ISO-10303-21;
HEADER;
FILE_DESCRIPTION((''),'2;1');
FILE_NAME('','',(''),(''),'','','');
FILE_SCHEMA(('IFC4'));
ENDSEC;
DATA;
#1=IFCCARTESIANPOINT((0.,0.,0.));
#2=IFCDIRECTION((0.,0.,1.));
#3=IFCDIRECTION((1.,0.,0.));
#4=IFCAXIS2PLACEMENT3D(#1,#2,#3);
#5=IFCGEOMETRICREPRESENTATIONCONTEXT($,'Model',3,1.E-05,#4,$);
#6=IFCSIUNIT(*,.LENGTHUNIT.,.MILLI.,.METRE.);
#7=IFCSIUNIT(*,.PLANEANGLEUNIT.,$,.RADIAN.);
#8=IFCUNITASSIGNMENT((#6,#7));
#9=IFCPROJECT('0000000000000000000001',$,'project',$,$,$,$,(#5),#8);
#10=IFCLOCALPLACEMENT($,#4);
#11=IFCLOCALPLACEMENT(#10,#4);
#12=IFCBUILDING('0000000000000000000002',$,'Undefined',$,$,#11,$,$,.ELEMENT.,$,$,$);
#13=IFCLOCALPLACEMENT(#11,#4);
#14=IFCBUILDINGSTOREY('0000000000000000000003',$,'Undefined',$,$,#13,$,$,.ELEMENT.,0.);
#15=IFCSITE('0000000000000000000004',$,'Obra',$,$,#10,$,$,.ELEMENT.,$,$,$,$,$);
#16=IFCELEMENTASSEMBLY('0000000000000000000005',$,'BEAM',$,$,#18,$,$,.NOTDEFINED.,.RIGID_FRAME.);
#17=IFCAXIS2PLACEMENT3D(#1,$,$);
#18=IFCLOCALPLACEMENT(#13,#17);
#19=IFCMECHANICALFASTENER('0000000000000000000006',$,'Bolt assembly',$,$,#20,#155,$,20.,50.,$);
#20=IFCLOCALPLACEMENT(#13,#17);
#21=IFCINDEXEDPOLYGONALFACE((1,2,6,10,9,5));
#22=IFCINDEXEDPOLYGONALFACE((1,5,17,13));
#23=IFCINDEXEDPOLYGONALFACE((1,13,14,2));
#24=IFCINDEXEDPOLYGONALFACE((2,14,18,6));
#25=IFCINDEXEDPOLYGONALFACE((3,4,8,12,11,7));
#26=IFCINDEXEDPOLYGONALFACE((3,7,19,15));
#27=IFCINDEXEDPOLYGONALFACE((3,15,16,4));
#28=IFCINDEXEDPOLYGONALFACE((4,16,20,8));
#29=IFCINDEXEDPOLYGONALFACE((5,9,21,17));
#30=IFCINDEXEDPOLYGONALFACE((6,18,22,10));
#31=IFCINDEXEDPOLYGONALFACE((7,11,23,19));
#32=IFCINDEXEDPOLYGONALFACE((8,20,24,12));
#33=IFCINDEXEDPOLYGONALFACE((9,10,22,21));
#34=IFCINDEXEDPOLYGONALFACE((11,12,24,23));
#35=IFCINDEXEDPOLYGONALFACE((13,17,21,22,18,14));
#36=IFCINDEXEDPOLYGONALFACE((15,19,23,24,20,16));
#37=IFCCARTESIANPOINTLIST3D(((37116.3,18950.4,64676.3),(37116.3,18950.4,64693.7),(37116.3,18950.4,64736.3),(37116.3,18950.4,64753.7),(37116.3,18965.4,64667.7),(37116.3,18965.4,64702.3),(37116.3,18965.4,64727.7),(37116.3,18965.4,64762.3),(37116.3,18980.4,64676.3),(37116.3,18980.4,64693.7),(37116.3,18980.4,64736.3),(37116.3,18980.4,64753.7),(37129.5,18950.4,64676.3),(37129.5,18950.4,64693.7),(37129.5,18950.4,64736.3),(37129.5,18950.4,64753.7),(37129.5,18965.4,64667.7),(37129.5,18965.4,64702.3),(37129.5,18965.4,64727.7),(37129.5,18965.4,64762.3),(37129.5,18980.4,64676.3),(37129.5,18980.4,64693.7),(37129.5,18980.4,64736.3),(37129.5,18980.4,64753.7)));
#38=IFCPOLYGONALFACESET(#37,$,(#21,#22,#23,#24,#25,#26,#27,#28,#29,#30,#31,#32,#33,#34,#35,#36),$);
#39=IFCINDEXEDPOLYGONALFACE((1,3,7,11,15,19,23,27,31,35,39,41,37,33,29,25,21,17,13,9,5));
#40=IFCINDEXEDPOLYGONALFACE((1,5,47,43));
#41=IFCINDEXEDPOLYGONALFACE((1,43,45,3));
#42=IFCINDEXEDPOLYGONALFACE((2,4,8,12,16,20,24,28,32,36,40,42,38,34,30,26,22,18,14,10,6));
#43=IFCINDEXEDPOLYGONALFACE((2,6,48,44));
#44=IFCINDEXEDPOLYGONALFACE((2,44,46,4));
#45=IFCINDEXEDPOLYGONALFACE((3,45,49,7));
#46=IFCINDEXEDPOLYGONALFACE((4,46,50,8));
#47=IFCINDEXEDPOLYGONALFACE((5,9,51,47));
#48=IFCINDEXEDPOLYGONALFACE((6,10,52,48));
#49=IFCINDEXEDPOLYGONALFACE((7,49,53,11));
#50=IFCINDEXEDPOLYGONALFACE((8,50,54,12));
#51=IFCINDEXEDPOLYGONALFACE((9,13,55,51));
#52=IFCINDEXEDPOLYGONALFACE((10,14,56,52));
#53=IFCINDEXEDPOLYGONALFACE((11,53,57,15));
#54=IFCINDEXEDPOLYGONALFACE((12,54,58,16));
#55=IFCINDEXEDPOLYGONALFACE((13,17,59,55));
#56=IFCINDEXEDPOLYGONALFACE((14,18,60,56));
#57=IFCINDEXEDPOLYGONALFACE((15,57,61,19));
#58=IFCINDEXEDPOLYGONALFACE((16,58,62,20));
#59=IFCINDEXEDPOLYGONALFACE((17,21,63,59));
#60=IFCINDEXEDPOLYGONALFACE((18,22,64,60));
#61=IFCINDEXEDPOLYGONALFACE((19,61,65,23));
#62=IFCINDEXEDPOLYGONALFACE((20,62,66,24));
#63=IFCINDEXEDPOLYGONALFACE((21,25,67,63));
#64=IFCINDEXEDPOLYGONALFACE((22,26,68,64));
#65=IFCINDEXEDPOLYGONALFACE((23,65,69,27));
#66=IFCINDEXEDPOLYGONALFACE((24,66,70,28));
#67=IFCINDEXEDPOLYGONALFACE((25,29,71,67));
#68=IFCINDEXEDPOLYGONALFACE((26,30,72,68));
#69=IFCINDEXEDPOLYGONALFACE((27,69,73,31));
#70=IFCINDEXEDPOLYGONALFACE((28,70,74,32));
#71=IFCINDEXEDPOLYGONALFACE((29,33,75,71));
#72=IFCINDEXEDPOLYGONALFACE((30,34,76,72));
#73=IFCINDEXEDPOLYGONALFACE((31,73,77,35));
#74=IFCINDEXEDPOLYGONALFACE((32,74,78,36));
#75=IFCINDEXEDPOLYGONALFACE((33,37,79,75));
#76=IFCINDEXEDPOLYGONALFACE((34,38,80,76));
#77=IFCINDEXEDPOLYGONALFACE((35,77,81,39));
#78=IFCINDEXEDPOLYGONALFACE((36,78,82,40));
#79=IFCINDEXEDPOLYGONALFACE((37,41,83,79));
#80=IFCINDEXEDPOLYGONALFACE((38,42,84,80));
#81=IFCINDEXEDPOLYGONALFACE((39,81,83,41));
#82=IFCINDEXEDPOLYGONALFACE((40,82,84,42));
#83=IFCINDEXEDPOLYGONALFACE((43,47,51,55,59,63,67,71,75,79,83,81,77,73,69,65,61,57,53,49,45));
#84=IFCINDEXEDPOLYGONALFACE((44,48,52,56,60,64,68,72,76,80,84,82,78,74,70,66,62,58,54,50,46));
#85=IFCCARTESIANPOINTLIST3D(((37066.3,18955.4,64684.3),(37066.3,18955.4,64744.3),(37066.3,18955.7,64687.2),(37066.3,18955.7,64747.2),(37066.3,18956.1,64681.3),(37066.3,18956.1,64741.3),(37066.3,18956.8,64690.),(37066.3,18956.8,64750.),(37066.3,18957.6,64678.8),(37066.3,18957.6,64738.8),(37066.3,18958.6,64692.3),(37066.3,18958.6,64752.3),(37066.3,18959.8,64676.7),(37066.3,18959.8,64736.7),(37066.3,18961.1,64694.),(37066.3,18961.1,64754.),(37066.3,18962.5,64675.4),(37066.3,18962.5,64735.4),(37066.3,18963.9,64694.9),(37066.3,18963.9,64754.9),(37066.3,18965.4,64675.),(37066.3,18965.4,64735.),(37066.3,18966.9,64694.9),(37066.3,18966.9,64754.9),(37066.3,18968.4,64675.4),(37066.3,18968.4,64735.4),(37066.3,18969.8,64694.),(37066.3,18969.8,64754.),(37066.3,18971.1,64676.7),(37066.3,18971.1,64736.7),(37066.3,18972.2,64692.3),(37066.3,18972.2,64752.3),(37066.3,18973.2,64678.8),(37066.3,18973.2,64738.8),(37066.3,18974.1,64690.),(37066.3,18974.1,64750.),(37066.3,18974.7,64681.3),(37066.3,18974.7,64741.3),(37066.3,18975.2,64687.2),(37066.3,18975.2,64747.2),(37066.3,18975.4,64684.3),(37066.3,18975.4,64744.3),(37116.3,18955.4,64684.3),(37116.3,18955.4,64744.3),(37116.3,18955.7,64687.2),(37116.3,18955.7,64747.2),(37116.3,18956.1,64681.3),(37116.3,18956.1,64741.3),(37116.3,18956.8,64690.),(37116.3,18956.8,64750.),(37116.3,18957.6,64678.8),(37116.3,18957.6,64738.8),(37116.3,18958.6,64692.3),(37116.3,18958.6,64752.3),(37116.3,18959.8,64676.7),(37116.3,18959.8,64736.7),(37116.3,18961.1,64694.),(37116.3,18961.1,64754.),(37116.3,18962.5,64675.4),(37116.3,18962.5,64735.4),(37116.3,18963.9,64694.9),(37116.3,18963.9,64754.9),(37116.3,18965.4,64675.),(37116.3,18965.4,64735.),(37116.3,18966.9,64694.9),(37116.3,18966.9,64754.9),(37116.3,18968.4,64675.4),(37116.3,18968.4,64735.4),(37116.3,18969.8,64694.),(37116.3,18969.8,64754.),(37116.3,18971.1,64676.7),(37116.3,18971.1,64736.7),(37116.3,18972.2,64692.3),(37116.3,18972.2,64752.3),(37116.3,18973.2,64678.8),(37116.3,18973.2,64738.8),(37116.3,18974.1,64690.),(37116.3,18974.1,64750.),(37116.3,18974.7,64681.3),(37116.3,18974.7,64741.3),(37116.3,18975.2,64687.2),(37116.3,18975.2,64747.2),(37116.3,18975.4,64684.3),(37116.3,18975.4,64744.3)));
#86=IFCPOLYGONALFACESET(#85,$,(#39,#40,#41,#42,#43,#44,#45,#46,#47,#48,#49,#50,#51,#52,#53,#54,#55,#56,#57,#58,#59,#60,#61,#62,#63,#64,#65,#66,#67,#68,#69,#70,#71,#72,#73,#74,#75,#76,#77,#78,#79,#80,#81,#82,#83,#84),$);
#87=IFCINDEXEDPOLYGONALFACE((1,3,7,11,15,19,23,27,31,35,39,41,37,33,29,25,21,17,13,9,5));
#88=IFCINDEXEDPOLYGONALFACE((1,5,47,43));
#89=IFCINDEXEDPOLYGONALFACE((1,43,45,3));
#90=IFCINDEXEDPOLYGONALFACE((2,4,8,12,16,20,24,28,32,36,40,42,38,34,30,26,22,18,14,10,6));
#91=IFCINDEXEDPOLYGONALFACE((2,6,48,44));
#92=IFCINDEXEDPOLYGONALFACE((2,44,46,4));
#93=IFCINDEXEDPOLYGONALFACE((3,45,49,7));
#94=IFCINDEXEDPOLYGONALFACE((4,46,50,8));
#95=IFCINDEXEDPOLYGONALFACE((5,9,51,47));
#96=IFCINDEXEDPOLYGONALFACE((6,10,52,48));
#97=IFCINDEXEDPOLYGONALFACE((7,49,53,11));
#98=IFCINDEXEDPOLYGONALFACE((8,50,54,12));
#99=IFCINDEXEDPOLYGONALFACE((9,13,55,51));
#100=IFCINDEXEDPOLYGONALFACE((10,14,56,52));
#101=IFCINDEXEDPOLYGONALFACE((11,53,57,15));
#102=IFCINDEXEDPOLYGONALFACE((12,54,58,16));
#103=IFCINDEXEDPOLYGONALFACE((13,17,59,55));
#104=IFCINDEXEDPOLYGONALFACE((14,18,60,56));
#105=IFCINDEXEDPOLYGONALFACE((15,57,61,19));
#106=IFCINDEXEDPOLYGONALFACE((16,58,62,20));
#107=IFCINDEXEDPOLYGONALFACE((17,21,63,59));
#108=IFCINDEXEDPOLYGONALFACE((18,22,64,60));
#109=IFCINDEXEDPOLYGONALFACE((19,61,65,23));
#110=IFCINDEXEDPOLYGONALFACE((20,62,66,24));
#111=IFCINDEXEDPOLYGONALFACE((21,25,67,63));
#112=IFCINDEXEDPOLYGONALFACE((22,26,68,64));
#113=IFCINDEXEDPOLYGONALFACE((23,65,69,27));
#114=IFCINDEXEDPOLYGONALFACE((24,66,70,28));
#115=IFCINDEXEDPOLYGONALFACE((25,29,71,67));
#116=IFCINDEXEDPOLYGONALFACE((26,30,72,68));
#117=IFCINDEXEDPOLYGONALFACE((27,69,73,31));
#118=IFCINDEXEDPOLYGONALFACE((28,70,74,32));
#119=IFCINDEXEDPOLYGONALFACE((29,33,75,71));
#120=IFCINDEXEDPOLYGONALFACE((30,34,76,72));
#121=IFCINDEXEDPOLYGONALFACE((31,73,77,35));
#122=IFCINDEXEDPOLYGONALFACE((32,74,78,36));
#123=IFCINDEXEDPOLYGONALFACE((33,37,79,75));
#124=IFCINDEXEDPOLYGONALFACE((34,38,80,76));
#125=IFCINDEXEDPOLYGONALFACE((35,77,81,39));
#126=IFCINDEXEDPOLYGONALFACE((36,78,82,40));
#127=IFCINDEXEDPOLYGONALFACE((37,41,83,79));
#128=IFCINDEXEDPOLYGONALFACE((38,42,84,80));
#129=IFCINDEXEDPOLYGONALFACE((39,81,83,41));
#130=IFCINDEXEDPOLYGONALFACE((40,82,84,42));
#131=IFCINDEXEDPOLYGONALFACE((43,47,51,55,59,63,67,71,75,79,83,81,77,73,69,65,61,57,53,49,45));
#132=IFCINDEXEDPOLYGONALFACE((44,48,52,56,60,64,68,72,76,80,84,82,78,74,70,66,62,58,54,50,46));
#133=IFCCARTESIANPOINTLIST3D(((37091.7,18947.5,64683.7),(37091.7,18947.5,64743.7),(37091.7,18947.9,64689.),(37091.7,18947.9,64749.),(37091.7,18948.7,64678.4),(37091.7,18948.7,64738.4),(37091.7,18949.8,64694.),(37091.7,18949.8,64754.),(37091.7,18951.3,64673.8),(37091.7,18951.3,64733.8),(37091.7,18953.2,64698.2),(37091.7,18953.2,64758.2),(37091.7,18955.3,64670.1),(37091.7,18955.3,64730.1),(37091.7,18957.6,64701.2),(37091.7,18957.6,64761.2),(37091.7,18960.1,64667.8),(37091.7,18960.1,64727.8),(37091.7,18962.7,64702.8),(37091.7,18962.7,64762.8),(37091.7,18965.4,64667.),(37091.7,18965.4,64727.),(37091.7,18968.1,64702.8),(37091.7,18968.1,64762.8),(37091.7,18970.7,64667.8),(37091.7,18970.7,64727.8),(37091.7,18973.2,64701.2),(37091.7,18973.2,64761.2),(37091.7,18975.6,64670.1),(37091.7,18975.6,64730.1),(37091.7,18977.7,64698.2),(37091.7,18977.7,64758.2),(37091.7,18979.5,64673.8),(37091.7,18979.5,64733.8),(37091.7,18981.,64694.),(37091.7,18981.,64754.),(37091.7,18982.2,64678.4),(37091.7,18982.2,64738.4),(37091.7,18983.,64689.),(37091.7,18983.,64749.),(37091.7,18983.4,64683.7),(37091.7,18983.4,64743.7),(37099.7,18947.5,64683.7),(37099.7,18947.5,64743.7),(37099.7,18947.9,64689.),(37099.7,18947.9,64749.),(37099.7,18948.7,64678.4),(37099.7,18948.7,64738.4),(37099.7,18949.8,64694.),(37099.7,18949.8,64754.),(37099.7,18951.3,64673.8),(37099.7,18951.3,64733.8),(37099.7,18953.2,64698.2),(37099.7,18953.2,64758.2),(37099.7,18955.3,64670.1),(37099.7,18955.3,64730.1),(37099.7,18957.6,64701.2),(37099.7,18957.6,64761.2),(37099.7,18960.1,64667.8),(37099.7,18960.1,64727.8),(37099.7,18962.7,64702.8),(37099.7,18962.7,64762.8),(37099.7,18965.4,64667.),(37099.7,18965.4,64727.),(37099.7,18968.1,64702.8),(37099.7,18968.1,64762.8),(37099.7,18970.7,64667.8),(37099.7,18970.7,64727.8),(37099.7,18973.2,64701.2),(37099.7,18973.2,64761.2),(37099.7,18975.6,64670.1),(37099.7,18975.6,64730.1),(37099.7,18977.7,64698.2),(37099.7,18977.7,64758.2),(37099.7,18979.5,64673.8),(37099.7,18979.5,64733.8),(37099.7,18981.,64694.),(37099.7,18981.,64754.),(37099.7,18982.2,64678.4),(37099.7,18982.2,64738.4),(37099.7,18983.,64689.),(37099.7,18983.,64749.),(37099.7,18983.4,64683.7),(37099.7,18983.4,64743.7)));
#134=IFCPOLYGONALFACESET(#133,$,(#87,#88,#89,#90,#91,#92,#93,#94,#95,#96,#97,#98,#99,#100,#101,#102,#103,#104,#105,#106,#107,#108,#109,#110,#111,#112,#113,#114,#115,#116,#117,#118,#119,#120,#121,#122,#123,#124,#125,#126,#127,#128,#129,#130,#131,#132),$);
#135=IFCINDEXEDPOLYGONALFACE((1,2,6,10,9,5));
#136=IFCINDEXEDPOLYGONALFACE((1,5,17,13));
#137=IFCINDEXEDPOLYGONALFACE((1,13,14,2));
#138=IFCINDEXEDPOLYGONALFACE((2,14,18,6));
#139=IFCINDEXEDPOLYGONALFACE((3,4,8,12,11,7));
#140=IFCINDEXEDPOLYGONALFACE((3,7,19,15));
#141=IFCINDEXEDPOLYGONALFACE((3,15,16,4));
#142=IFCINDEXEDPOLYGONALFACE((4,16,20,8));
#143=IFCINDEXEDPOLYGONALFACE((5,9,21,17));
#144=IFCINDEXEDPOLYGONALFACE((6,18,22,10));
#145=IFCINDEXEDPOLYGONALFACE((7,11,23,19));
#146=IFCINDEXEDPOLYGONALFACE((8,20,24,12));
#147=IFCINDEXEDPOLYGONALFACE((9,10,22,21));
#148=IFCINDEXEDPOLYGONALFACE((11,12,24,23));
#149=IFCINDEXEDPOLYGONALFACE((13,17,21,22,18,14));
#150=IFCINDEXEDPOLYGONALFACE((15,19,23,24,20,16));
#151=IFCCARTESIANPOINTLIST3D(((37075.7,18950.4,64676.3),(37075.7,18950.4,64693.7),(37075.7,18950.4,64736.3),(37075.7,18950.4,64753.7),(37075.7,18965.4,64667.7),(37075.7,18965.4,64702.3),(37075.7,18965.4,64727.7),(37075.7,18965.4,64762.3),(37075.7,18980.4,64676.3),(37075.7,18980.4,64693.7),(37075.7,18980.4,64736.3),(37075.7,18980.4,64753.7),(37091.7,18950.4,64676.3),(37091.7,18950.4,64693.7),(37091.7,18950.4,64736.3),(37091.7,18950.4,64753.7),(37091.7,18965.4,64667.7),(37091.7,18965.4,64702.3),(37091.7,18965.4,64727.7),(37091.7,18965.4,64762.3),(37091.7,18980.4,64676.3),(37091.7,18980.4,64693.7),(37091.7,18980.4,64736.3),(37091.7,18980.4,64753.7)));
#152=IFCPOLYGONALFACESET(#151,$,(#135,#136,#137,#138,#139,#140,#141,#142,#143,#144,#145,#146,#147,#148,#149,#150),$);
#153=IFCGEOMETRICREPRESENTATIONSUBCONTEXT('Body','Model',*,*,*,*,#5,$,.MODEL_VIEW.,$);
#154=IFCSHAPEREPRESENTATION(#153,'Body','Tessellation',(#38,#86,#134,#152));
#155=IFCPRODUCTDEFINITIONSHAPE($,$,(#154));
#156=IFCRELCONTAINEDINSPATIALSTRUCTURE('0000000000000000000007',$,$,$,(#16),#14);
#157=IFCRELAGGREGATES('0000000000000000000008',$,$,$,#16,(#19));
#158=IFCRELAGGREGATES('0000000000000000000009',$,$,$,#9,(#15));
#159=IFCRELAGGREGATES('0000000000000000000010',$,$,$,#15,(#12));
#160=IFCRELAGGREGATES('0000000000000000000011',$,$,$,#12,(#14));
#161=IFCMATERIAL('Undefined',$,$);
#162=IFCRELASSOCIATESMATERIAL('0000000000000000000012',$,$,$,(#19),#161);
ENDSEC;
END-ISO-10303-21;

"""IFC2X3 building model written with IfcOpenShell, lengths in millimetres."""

from ifc_helpers import new_model, si_unit, frame, origin_with_axes, origin_2d_with_axis, place, context, subcontext, project, spatial, polyline, circle, outline, extrude, source, transform, mapped, material, element, aggregate, save


model = new_model("IFC2X3")

# Units and contexts
model_context = context("Model", 3, precision=1e-05, world=origin_with_axes())
body_context = subcontext(model_context, "Body", "Model", "MODEL_VIEW")
ifc_project = project(units=[si_unit("LENGTHUNIT", "METRE", prefix="MILLI"), si_unit("PLANEANGLEUNIT", "RADIAN")], contexts=[model_context])

# Site, building, storey
site_placement = place(None, origin_with_axes())
site = spatial("IfcSite", under=ifc_project, at=site_placement, Name="Obra", CompositionType="ELEMENT")
building_placement = place(site_placement, origin_with_axes())
building = spatial("IfcBuilding", under=site, at=building_placement, Name="Undefined", CompositionType="ELEMENT")
storey_placement = place(building_placement, origin_with_axes())
storey = spatial("IfcBuildingStorey", under=building, at=storey_placement, Name="Undefined", CompositionType="ELEMENT", Elevation=0.0)

# Element assembly
ifc_material = material(Name="Undefined")
shared_shape_1 = source(origin_with_axes(), body_context, "Body", "SweptSolid", [
    extrude(outline(polyline([(17.3, 0.0), (8.7, 15.0), (-8.7, 15.0), (-17.3, 0.0), (-8.7, -15.0), (8.7, -15.0), (17.3, 0.0)])), frame((0.0, -26.5, 0.0), z_axis=(0.0, 1.0, 0.0), x_axis=(1.0, 0.0, 0.0)), (0.0, 0.0, 1.0), 13.2),
    extrude(circle(Radius=10.0, at=origin_2d_with_axis()), frame((0.0, -13.3, 0.0), z_axis=(0.0, 1.0, 0.0), x_axis=(1.0, 0.0, 0.0)), (0.0, 0.0, 1.0), 50.0),
    extrude(circle(Radius=18.0, at=origin_2d_with_axis()), frame((0.0, 3.3, 0.0), z_axis=(0.0, 1.0, 0.0), x_axis=(1.0, 0.0, 0.0)), (0.0, 0.0, 1.0), 8.0),
    extrude(outline(polyline([(17.3, 0.0), (8.7, 15.0), (-8.7, 15.0), (-17.3, 0.0), (-8.7, -15.0), (8.7, -15.0), (17.3, 0.0)])), frame((0.0, 11.3, 0.0), z_axis=(0.0, 1.0, 0.0), x_axis=(1.0, 0.0, 0.0)), (0.0, 0.0, 1.0), 16.0),
])
assembly_1_placement = place(storey_placement, origin_with_axes())
assembly_1 = element("IfcElementAssembly", 1, at=assembly_1_placement, inside=storey, Name="BEAM", AssemblyPlace="NOTDEFINED", PredefinedType="RIGID_FRAME")

# Mechanical fastener
mechanical_fastener_1_placement = place(assembly_1_placement, frame((37103.0, 18925.4, 64850.0), z_axis=(0.0, 1.0, 0.0), x_axis=(0.0, 0.0, -1.0)))
mechanical_fastener_1 = element("IfcMechanicalFastener", 2, at=mechanical_fastener_1_placement, material=ifc_material, Name="Bolt assembly", NominalDiameter=20.0, NominalLength=50.0, context=body_context, shape_type="MappedRepresentation", body=[
    mapped(shared_shape_1, transform((105.0, 0.0, 40.0))),
    mapped(shared_shape_1, transform((165.0, 0.0, 40.0))),
])
aggregate(assembly_1, [mechanical_fastener_1])

save(model, "model.ifc")
